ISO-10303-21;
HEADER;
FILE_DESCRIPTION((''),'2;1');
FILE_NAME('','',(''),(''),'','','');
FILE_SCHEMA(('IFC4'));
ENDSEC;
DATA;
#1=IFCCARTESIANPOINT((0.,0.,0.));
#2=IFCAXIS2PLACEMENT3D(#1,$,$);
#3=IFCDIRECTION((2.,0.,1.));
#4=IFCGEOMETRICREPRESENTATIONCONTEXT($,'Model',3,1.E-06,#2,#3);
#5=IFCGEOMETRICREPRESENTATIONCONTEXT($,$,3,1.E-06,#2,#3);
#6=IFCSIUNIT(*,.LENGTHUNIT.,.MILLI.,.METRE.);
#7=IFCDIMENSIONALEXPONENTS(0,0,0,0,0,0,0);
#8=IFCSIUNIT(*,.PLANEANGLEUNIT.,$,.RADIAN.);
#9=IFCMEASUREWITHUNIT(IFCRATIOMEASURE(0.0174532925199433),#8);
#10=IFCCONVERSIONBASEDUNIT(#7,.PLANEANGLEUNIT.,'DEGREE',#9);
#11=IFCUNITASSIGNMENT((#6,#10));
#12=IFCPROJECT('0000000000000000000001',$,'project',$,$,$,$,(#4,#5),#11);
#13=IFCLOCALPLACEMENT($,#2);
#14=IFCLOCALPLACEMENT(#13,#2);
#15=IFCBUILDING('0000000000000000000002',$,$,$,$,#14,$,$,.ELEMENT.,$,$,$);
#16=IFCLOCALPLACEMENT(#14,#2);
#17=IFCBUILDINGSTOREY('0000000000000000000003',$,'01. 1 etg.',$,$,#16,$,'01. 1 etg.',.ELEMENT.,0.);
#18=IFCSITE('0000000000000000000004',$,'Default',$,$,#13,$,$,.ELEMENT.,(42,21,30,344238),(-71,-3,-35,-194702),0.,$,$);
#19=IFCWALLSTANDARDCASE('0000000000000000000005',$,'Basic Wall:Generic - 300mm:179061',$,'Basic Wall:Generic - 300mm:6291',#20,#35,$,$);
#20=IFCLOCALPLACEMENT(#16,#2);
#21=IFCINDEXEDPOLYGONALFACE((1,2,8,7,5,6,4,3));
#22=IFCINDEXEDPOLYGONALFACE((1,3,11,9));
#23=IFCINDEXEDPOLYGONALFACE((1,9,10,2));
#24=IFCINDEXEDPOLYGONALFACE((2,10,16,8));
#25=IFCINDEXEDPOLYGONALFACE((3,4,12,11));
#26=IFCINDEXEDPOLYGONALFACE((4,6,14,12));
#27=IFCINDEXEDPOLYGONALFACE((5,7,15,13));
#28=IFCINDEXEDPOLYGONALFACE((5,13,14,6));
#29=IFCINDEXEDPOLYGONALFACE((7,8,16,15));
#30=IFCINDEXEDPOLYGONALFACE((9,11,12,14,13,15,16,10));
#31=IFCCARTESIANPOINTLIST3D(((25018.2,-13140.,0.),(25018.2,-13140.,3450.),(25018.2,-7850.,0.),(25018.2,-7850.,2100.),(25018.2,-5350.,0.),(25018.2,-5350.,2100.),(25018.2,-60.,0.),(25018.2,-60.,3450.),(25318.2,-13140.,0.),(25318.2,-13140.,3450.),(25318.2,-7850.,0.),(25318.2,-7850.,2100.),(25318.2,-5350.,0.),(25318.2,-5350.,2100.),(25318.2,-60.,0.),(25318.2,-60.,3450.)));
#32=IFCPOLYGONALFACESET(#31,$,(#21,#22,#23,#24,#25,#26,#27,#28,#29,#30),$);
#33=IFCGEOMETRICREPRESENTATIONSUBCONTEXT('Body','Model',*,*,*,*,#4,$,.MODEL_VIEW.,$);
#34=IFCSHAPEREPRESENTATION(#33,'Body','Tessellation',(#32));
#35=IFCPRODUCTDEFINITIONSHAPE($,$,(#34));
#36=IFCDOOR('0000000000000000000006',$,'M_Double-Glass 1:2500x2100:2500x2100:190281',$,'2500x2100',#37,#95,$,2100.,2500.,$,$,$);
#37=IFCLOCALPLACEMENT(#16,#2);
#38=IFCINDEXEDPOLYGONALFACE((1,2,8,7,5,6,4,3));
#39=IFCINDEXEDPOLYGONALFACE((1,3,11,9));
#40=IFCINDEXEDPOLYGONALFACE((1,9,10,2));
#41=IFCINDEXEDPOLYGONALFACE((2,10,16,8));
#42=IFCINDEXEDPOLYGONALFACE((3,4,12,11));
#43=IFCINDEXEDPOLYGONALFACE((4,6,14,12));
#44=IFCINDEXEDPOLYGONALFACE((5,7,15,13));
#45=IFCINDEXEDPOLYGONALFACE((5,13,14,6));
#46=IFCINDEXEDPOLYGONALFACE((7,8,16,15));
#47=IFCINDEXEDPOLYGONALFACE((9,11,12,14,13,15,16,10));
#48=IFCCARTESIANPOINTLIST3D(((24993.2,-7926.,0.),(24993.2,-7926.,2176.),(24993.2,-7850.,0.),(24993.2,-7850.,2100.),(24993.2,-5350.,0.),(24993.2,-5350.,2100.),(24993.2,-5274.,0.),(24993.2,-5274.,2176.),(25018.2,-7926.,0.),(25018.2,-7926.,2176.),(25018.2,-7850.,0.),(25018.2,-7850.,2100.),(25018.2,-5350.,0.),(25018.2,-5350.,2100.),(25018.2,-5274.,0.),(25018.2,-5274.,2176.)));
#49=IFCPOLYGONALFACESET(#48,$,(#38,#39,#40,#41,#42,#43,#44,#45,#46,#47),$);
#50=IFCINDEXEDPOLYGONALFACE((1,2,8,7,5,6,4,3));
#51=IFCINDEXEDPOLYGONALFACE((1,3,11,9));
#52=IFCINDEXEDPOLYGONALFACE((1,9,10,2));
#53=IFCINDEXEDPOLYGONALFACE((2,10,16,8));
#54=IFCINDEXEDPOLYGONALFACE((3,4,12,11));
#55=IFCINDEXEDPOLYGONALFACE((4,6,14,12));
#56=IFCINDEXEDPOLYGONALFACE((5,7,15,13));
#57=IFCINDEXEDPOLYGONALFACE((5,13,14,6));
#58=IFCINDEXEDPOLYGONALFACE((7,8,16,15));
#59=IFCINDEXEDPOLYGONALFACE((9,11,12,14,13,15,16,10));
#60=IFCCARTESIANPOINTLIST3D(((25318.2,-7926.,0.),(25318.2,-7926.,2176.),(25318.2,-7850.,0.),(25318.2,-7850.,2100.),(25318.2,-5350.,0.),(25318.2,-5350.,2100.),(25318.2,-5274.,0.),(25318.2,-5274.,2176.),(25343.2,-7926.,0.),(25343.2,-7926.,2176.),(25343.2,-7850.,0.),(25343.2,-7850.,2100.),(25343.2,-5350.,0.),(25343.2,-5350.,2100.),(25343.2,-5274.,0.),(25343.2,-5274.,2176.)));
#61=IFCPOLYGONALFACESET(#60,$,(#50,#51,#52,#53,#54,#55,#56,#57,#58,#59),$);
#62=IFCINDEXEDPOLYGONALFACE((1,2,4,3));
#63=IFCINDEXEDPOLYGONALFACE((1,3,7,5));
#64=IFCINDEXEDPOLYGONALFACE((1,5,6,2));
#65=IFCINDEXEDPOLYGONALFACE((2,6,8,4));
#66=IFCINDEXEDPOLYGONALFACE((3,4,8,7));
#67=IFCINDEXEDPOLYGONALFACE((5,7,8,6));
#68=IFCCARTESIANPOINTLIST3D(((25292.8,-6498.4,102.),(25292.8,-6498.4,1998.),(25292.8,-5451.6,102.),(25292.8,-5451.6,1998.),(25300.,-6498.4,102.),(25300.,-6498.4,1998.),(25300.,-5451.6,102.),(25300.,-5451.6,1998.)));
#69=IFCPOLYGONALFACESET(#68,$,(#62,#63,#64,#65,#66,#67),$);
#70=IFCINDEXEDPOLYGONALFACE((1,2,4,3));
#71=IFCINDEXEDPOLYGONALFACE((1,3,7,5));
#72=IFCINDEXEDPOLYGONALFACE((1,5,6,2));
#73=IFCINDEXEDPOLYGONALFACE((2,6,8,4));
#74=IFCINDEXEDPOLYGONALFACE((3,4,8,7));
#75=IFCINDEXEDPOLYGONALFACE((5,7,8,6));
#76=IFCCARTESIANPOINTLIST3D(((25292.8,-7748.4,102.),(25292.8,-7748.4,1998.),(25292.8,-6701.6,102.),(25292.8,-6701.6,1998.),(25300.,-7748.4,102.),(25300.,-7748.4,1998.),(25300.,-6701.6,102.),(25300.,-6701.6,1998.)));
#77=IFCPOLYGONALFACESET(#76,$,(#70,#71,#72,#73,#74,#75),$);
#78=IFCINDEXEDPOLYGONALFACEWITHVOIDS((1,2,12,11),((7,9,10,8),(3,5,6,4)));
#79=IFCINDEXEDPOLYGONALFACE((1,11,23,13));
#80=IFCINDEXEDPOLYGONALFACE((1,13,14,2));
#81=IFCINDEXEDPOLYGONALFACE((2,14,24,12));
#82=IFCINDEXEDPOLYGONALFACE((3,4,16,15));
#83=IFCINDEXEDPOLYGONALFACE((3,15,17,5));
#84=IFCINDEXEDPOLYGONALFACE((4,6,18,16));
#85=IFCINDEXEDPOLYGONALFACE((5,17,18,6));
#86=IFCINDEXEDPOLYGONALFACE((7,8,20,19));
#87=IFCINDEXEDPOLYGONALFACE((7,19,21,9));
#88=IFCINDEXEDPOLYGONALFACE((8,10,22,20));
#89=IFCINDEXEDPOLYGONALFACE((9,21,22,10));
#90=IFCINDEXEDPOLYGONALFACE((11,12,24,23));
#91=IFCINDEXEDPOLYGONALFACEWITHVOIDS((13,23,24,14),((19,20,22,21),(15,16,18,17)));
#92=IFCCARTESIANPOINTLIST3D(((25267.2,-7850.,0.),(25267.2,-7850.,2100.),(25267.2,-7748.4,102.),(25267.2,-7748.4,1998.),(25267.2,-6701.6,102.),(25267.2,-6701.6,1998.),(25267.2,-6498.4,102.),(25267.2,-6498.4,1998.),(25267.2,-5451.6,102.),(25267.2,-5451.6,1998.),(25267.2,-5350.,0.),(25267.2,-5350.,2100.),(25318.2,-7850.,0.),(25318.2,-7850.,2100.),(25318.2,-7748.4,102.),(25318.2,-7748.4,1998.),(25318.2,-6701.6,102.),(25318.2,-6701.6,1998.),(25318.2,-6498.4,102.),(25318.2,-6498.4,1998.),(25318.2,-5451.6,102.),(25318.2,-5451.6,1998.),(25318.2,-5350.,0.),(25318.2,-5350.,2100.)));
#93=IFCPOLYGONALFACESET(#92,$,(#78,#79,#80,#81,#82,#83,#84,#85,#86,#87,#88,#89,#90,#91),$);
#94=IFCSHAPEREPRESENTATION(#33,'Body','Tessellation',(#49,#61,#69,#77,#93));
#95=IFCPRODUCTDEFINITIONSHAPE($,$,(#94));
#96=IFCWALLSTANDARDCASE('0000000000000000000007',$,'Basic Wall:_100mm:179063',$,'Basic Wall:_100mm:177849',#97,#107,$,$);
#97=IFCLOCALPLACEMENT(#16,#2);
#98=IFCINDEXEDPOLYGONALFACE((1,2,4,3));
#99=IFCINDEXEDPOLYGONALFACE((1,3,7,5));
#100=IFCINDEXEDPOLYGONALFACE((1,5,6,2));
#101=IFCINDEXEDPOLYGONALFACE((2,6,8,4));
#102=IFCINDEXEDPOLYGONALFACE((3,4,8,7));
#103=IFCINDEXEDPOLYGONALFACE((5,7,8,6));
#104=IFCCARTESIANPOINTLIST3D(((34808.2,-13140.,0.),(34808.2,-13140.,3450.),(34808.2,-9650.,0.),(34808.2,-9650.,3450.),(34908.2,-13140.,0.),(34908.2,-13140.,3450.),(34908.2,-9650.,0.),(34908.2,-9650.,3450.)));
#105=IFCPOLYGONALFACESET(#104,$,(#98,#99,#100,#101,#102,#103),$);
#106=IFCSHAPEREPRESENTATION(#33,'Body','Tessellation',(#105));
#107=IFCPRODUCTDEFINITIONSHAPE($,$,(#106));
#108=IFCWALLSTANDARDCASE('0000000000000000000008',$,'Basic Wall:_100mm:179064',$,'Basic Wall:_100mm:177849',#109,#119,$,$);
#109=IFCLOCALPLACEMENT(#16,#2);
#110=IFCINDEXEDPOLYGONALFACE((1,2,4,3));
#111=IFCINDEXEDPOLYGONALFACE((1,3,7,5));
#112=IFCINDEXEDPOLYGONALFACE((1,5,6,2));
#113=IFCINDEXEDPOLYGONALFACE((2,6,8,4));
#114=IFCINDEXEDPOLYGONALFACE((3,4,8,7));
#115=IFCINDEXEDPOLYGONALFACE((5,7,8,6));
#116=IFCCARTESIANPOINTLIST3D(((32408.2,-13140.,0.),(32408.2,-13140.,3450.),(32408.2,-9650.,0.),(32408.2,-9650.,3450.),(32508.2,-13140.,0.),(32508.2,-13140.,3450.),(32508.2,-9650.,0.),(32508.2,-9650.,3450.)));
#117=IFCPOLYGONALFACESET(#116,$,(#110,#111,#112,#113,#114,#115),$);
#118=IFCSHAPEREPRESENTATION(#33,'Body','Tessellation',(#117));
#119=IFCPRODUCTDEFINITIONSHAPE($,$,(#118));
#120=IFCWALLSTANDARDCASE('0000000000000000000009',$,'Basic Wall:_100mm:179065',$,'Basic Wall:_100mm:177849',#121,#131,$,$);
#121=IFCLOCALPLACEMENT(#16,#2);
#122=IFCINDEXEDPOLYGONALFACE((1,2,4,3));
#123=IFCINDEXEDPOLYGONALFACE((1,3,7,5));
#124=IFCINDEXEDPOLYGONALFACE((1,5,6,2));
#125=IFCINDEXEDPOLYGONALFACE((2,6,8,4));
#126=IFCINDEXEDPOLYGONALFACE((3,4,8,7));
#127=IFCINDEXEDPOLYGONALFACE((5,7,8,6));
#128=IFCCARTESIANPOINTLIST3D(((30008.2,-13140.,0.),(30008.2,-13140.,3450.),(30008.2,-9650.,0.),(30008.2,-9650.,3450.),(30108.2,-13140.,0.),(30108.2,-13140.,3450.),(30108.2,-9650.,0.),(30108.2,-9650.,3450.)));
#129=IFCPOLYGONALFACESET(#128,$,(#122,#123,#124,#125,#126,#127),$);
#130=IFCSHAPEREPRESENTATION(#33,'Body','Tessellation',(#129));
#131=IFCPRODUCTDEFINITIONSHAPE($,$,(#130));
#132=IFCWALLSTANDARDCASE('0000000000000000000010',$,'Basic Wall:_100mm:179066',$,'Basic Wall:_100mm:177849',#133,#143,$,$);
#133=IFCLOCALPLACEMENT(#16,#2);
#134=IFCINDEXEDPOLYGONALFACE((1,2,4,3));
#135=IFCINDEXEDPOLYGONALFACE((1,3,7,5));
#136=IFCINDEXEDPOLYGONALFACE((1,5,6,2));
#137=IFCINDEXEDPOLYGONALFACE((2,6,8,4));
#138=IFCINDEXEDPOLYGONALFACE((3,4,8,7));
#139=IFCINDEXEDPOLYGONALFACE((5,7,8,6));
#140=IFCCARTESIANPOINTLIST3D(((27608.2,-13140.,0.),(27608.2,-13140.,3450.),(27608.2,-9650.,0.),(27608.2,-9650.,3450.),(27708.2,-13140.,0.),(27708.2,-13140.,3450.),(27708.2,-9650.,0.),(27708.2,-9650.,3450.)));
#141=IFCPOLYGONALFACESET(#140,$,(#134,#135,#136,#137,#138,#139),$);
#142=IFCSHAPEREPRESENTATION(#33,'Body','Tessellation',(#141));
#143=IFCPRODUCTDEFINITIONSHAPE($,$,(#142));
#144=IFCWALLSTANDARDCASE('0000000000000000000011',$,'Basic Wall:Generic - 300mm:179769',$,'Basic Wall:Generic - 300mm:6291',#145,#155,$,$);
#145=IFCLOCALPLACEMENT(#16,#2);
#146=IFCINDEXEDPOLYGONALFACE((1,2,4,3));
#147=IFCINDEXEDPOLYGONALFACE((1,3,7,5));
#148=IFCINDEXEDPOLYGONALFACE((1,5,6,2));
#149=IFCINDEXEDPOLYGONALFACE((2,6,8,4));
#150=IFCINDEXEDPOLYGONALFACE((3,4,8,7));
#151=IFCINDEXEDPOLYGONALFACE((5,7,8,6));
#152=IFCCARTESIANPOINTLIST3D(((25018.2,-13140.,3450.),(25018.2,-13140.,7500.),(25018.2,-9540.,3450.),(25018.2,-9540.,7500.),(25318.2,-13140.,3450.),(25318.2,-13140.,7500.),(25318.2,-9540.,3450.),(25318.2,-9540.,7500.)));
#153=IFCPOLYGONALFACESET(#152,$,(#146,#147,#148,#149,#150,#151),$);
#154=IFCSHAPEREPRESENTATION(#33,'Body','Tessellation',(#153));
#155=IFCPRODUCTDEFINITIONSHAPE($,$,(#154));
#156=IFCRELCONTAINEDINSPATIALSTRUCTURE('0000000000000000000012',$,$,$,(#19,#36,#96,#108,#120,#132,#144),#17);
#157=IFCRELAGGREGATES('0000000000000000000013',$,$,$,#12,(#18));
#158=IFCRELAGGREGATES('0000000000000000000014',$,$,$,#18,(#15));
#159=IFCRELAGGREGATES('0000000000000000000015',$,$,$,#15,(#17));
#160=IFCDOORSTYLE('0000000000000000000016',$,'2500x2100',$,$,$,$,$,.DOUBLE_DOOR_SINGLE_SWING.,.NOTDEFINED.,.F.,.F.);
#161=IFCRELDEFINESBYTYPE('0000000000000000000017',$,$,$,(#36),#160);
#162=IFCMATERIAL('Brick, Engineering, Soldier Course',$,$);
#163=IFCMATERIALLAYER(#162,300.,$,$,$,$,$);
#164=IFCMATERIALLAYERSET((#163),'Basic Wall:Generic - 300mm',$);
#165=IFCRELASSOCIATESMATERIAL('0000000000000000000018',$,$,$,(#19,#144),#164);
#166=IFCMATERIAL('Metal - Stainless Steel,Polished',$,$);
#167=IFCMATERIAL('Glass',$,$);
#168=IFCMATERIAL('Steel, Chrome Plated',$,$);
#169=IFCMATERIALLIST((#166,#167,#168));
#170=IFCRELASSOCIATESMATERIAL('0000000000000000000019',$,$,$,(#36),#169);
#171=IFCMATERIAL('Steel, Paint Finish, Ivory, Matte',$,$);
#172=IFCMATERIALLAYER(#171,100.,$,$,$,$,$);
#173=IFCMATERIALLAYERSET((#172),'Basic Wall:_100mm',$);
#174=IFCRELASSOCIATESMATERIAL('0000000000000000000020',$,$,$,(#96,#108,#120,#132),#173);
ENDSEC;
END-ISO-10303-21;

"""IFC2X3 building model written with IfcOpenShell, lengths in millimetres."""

from ifc_helpers import new_model, entity, si_unit, converted_unit, direction, frame, frame_2d, origin, place, context, subcontext, project, spatial, polyline, rectangle, outline, extrude, clip, bounded_halfspace, source, transform, mapped, material, material_list, layer, layer_set, layer_usage, type_object, type_shapes, element, fill, save


model = new_model("IFC2X3")

# Units and contexts
model_context = context("Model", 3, precision=1e-06, world=origin(), true_north=direction((2.0, 0.0, 1.0)))
context_of_model = context(None, 3, precision=1e-06, world=origin(), true_north=direction((2.0, 0.0, 1.0)))
body_context = subcontext(model_context, "Body", "Model", "MODEL_VIEW")
ifc_project = project(units=[si_unit("LENGTHUNIT", "METRE", prefix="MILLI"), converted_unit("PLANEANGLEUNIT", "DEGREE", entity("IfcRatioMeasure", 0.0174532925199433), si_unit("PLANEANGLEUNIT", "RADIAN"), dimensions=[0, 0, 0, 0, 0, 0, 0])], contexts=[model_context, context_of_model])

# Site, building, storey
site_placement = place(None, origin())
site = spatial("IfcSite", under=ifc_project, at=site_placement, Name="Default", CompositionType="ELEMENT", RefLatitude=(42, 21, 30, 344238), RefLongitude=(-71, -3, -35, -194702), RefElevation=0.0)
building_placement = place(site_placement, origin())
building = spatial("IfcBuilding", under=site, at=building_placement, CompositionType="ELEMENT")
storey_placement = place(building_placement, origin())
storey = spatial("IfcBuildingStorey", under=building, at=storey_placement, Name="01. 1 etg.", LongName="01. 1 etg.", CompositionType="ELEMENT", Elevation=0.0)

# Shared definitions
ifc_material_1 = material(Name="Glass")

# Shared definitions
ifc_material_2 = material(Name="Brick, Engineering, Soldier Course")
ifc_layer_1 = layer(ifc_material_2, 300.0)
ifc_layer_set_1 = layer_set([ifc_layer_1], Name="Basic Wall:Generic - 300mm")

# Wall, opening, door
ifc_layer_usage_1 = layer_usage(ifc_layer_set_1, "AXIS2", "NEGATIVE", 150.0)
wall_1_placement = place(storey_placement, frame((25168.2, -13140.0, 0.0), z_axis=(0.0, 0.0, 1.0), x_axis=(0.0, 1.0, 0.0)))
wall_1 = element("IfcWallStandardCase", 1, at=wall_1_placement, inside=storey, material=ifc_layer_usage_1, Name="Basic Wall:Generic - 300mm:179061", ObjectType="Basic Wall:Generic - 300mm:6291", context=body_context, shape_type="Clipping", body=[
    clip(extrude(rectangle(XDim=13080.0, YDim=300.0, at=frame_2d((6540.0, 0.0), x_axis=(-1.0, 0.0))), origin(), (0.0, 0.0, 1.0), 3450.0), bounded_halfspace(frame((3590.0, -150.0, 3450.0), z_axis=(0.0, 0.0, -1.0), x_axis=(-1.0, 0.0, 0.0)), True, frame((3590.0, -150.0, 3450.0)), polyline([(0.0, 0.0), (10.0, 0.0), (5900.0, 0.0), (5900.0, 300.0), (10.0, 300.0), (0.0, 300.0), (0.0, 0.0)]))),
])
opening_1_placement = place(wall_1_placement, frame((7790.0, 150.0, 0.0)))
opening_1 = element("IfcOpeningElement", 2, at=opening_1_placement, cuts=wall_1, ObjectType="Opening", context=body_context, shape_type="SweptSolid", body=[
    extrude(rectangle(XDim=2500.0, YDim=2100.0, at=frame_2d((1050.0, 1250.0), x_axis=(0.0, -1.0))), frame((0.0, 0.0, 0.0), z_axis=(0.0, -1.0, 0.0), x_axis=(0.0, 0.0, 1.0)), (0.0, 0.0, 1.0), 300.0),
])
ifc_material_3 = material(Name="Metal - Stainless Steel,Polished")
ifc_material_4 = material(Name="Steel, Chrome Plated")
ifc_material_list_1 = material_list([ifc_material_3, ifc_material_1, ifc_material_4])
door_style_1 = type_object("IfcDoorStyle", Name="2500x2100", ConstructionType="NOTDEFINED", OperationType="DOUBLE_DOOR_SINGLE_SWING", ParameterTakesPrecedence=False, Sizeable=False)
shared_shape_1 = source(origin(), body_context, "Body", "SweptSolid", [
    extrude(outline(polyline([(-1326.0, -1069.0), (-1250.0, -1069.0), (-1250.0, 1031.0), (1250.0, 1031.0), (1250.0, -1069.0), (1326.0, -1069.0), (1326.0, 1107.0), (-1326.0, 1107.0), (-1326.0, -1069.0)])), frame((1250.0, 4.8, 1069.0), z_axis=(0.0, -1.0, 0.0), x_axis=(1.0, 0.0, 0.0)), (0.0, 0.0, 1.0), 25.0),
    extrude(outline(polyline([(-1250.0, -1031.0), (-1250.0, 1069.0), (-1326.0, 1069.0), (-1326.0, -1107.0), (1326.0, -1107.0), (1326.0, 1069.0), (1250.0, 1069.0), (1250.0, -1031.0), (-1250.0, -1031.0)])), frame((1250.0, 329.8, 1069.0), z_axis=(0.0, 1.0, 0.0), x_axis=(1.0, 0.0, 0.0)), (0.0, 0.0, -1.0), 25.0),
    extrude(rectangle(XDim=1046.8, YDim=7.1, at=frame_2d((0.0, 0.0), x_axis=(1.0, 0.0))), frame((625.0, 282.9, 102.0)), (0.0, 0.0, 1.0), 1896.0),
    extrude(rectangle(XDim=1046.8, YDim=7.1, at=frame_2d((0.0, 0.0), x_axis=(1.0, 0.0))), frame((1875.0, 282.9, 102.0)), (0.0, 0.0, 1.0), 1896.0),
    extrude(outline(polyline([(-1050.0, -1250.0), (1050.0, -1250.0), (1050.0, 1250.0), (-1050.0, 1250.0), (-1050.0, -1250.0)]), holes=[polyline([(-948.0, 101.6), (-948.0, 1148.4), (948.0, 1148.4), (948.0, 101.6), (-948.0, 101.6)]), polyline([(-948.0, -1148.4), (-948.0, -101.6), (948.0, -101.6), (948.0, -1148.4), (-948.0, -1148.4)])]), frame((1250.0, 304.8, 1050.0), z_axis=(0.0, -1.0, 0.0), x_axis=(0.0, 0.0, -1.0)), (0.0, 0.0, 1.0), 51.0),
])
type_shapes(door_style_1, [shared_shape_1])
door_1_placement = place(opening_1_placement, frame((0.0, 4.8, 0.0), z_axis=(0.0, 0.0, 1.0), x_axis=(-1.0, 0.0, 0.0)))
door_1 = element("IfcDoor", 3, at=door_1_placement, inside=storey, type_object=door_style_1, material=ifc_material_list_1, Name="M_Double-Glass 1:2500x2100:2500x2100:190281", ObjectType="2500x2100", OverallHeight=2100.0, OverallWidth=2500.0, context=body_context, shape_type="MappedRepresentation", body=[
    mapped(shared_shape_1, transform((0.0, 0.0, 0.0), scale=1.0)),
])
fill(opening_1, door_1)

# Shared definitions
ifc_material_5 = material(Name="Steel, Paint Finish, Ivory, Matte")
ifc_layer_2 = layer(ifc_material_5, 100.0)
ifc_layer_set_2 = layer_set([ifc_layer_2], Name="Basic Wall:_100mm")

# Walls
ifc_layer_usage_2 = layer_usage(ifc_layer_set_2, "AXIS2", "POSITIVE", -50.0)
wall_2_placement = place(storey_placement, frame((34858.2, -13140.0, 0.0), z_axis=(0.0, 0.0, 1.0), x_axis=(0.0, 1.0, 0.0)))
element("IfcWallStandardCase", 4, at=wall_2_placement, inside=storey, material=ifc_layer_usage_2, Name="Basic Wall:_100mm:179063", ObjectType="Basic Wall:_100mm:177849", context=body_context, shape_type="Clipping", body=[
    clip(extrude(rectangle(XDim=3490.0, YDim=100.0, at=frame_2d((1745.0, 0.0), x_axis=(-1.0, 0.0))), origin(), (0.0, 0.0, 1.0), 3450.0), bounded_halfspace(frame((0.0, -50.0, 3450.0), z_axis=(0.0, 0.0, -1.0), x_axis=(-1.0, 0.0, 0.0)), True, frame((0.0, -50.0, 3450.0)), polyline([(0.0, 0.0), (3490.0, 0.0), (3490.0, 100.0), (0.0, 100.0), (0.0, 0.0)]))),
])
ifc_layer_usage_3 = layer_usage(ifc_layer_set_2, "AXIS2", "POSITIVE", -50.0)
wall_3_placement = place(storey_placement, frame((32458.2, -13140.0, 0.0), z_axis=(0.0, 0.0, 1.0), x_axis=(0.0, 1.0, 0.0)))
element("IfcWallStandardCase", 5, at=wall_3_placement, inside=storey, material=ifc_layer_usage_3, Name="Basic Wall:_100mm:179064", ObjectType="Basic Wall:_100mm:177849", context=body_context, shape_type="Clipping", body=[
    clip(extrude(rectangle(XDim=3490.0, YDim=100.0, at=frame_2d((1745.0, 0.0), x_axis=(-1.0, 0.0))), origin(), (0.0, 0.0, 1.0), 3450.0), bounded_halfspace(frame((0.0, -50.0, 3450.0), z_axis=(0.0, 0.0, -1.0), x_axis=(-1.0, 0.0, 0.0)), True, frame((0.0, -50.0, 3450.0)), polyline([(0.0, 0.0), (3490.0, 0.0), (3490.0, 100.0), (0.0, 100.0), (0.0, 0.0)]))),
])
ifc_layer_usage_4 = layer_usage(ifc_layer_set_2, "AXIS2", "POSITIVE", -50.0)
wall_4_placement = place(storey_placement, frame((30058.2, -13140.0, 0.0), z_axis=(0.0, 0.0, 1.0), x_axis=(0.0, 1.0, 0.0)))
element("IfcWallStandardCase", 6, at=wall_4_placement, inside=storey, material=ifc_layer_usage_4, Name="Basic Wall:_100mm:179065", ObjectType="Basic Wall:_100mm:177849", context=body_context, shape_type="Clipping", body=[
    clip(extrude(rectangle(XDim=3490.0, YDim=100.0, at=frame_2d((1745.0, 0.0), x_axis=(-1.0, 0.0))), origin(), (0.0, 0.0, 1.0), 3450.0), bounded_halfspace(frame((0.0, -50.0, 3450.0), z_axis=(0.0, 0.0, -1.0), x_axis=(-1.0, 0.0, 0.0)), True, frame((0.0, -50.0, 3450.0)), polyline([(0.0, 0.0), (3490.0, 0.0), (3490.0, 100.0), (0.0, 100.0), (0.0, 0.0)]))),
])
ifc_layer_usage_5 = layer_usage(ifc_layer_set_2, "AXIS2", "POSITIVE", -50.0)
wall_5_placement = place(storey_placement, frame((27658.2, -13140.0, 0.0), z_axis=(0.0, 0.0, 1.0), x_axis=(0.0, 1.0, 0.0)))
element("IfcWallStandardCase", 7, at=wall_5_placement, inside=storey, material=ifc_layer_usage_5, Name="Basic Wall:_100mm:179066", ObjectType="Basic Wall:_100mm:177849", context=body_context, shape_type="Clipping", body=[
    clip(extrude(rectangle(XDim=3490.0, YDim=100.0, at=frame_2d((1745.0, 0.0), x_axis=(-1.0, 0.0))), origin(), (0.0, 0.0, 1.0), 3450.0), bounded_halfspace(frame((0.0, -50.0, 3450.0), z_axis=(0.0, 0.0, -1.0), x_axis=(-1.0, 0.0, 0.0)), True, frame((0.0, -50.0, 3450.0)), polyline([(0.0, 0.0), (3490.0, 0.0), (3490.0, 100.0), (0.0, 100.0), (0.0, 0.0)]))),
])
ifc_layer_usage_6 = layer_usage(ifc_layer_set_1, "AXIS2", "NEGATIVE", 150.0)
wall_6_placement = place(storey_placement, frame((25168.2, -13140.0, 3450.0), z_axis=(0.0, 0.0, 1.0), x_axis=(0.0, 1.0, 0.0)))
element("IfcWallStandardCase", 8, at=wall_6_placement, inside=storey, material=ifc_layer_usage_6, Name="Basic Wall:Generic - 300mm:179769", ObjectType="Basic Wall:Generic - 300mm:6291", context=body_context, shape_type="SweptSolid", body=[
    extrude(rectangle(XDim=3600.0, YDim=300.0, at=frame_2d((1800.0, 0.0), x_axis=(-1.0, 0.0))), origin(), (0.0, 0.0, 1.0), 4050.0),
])

save(model, "model.ifc")
